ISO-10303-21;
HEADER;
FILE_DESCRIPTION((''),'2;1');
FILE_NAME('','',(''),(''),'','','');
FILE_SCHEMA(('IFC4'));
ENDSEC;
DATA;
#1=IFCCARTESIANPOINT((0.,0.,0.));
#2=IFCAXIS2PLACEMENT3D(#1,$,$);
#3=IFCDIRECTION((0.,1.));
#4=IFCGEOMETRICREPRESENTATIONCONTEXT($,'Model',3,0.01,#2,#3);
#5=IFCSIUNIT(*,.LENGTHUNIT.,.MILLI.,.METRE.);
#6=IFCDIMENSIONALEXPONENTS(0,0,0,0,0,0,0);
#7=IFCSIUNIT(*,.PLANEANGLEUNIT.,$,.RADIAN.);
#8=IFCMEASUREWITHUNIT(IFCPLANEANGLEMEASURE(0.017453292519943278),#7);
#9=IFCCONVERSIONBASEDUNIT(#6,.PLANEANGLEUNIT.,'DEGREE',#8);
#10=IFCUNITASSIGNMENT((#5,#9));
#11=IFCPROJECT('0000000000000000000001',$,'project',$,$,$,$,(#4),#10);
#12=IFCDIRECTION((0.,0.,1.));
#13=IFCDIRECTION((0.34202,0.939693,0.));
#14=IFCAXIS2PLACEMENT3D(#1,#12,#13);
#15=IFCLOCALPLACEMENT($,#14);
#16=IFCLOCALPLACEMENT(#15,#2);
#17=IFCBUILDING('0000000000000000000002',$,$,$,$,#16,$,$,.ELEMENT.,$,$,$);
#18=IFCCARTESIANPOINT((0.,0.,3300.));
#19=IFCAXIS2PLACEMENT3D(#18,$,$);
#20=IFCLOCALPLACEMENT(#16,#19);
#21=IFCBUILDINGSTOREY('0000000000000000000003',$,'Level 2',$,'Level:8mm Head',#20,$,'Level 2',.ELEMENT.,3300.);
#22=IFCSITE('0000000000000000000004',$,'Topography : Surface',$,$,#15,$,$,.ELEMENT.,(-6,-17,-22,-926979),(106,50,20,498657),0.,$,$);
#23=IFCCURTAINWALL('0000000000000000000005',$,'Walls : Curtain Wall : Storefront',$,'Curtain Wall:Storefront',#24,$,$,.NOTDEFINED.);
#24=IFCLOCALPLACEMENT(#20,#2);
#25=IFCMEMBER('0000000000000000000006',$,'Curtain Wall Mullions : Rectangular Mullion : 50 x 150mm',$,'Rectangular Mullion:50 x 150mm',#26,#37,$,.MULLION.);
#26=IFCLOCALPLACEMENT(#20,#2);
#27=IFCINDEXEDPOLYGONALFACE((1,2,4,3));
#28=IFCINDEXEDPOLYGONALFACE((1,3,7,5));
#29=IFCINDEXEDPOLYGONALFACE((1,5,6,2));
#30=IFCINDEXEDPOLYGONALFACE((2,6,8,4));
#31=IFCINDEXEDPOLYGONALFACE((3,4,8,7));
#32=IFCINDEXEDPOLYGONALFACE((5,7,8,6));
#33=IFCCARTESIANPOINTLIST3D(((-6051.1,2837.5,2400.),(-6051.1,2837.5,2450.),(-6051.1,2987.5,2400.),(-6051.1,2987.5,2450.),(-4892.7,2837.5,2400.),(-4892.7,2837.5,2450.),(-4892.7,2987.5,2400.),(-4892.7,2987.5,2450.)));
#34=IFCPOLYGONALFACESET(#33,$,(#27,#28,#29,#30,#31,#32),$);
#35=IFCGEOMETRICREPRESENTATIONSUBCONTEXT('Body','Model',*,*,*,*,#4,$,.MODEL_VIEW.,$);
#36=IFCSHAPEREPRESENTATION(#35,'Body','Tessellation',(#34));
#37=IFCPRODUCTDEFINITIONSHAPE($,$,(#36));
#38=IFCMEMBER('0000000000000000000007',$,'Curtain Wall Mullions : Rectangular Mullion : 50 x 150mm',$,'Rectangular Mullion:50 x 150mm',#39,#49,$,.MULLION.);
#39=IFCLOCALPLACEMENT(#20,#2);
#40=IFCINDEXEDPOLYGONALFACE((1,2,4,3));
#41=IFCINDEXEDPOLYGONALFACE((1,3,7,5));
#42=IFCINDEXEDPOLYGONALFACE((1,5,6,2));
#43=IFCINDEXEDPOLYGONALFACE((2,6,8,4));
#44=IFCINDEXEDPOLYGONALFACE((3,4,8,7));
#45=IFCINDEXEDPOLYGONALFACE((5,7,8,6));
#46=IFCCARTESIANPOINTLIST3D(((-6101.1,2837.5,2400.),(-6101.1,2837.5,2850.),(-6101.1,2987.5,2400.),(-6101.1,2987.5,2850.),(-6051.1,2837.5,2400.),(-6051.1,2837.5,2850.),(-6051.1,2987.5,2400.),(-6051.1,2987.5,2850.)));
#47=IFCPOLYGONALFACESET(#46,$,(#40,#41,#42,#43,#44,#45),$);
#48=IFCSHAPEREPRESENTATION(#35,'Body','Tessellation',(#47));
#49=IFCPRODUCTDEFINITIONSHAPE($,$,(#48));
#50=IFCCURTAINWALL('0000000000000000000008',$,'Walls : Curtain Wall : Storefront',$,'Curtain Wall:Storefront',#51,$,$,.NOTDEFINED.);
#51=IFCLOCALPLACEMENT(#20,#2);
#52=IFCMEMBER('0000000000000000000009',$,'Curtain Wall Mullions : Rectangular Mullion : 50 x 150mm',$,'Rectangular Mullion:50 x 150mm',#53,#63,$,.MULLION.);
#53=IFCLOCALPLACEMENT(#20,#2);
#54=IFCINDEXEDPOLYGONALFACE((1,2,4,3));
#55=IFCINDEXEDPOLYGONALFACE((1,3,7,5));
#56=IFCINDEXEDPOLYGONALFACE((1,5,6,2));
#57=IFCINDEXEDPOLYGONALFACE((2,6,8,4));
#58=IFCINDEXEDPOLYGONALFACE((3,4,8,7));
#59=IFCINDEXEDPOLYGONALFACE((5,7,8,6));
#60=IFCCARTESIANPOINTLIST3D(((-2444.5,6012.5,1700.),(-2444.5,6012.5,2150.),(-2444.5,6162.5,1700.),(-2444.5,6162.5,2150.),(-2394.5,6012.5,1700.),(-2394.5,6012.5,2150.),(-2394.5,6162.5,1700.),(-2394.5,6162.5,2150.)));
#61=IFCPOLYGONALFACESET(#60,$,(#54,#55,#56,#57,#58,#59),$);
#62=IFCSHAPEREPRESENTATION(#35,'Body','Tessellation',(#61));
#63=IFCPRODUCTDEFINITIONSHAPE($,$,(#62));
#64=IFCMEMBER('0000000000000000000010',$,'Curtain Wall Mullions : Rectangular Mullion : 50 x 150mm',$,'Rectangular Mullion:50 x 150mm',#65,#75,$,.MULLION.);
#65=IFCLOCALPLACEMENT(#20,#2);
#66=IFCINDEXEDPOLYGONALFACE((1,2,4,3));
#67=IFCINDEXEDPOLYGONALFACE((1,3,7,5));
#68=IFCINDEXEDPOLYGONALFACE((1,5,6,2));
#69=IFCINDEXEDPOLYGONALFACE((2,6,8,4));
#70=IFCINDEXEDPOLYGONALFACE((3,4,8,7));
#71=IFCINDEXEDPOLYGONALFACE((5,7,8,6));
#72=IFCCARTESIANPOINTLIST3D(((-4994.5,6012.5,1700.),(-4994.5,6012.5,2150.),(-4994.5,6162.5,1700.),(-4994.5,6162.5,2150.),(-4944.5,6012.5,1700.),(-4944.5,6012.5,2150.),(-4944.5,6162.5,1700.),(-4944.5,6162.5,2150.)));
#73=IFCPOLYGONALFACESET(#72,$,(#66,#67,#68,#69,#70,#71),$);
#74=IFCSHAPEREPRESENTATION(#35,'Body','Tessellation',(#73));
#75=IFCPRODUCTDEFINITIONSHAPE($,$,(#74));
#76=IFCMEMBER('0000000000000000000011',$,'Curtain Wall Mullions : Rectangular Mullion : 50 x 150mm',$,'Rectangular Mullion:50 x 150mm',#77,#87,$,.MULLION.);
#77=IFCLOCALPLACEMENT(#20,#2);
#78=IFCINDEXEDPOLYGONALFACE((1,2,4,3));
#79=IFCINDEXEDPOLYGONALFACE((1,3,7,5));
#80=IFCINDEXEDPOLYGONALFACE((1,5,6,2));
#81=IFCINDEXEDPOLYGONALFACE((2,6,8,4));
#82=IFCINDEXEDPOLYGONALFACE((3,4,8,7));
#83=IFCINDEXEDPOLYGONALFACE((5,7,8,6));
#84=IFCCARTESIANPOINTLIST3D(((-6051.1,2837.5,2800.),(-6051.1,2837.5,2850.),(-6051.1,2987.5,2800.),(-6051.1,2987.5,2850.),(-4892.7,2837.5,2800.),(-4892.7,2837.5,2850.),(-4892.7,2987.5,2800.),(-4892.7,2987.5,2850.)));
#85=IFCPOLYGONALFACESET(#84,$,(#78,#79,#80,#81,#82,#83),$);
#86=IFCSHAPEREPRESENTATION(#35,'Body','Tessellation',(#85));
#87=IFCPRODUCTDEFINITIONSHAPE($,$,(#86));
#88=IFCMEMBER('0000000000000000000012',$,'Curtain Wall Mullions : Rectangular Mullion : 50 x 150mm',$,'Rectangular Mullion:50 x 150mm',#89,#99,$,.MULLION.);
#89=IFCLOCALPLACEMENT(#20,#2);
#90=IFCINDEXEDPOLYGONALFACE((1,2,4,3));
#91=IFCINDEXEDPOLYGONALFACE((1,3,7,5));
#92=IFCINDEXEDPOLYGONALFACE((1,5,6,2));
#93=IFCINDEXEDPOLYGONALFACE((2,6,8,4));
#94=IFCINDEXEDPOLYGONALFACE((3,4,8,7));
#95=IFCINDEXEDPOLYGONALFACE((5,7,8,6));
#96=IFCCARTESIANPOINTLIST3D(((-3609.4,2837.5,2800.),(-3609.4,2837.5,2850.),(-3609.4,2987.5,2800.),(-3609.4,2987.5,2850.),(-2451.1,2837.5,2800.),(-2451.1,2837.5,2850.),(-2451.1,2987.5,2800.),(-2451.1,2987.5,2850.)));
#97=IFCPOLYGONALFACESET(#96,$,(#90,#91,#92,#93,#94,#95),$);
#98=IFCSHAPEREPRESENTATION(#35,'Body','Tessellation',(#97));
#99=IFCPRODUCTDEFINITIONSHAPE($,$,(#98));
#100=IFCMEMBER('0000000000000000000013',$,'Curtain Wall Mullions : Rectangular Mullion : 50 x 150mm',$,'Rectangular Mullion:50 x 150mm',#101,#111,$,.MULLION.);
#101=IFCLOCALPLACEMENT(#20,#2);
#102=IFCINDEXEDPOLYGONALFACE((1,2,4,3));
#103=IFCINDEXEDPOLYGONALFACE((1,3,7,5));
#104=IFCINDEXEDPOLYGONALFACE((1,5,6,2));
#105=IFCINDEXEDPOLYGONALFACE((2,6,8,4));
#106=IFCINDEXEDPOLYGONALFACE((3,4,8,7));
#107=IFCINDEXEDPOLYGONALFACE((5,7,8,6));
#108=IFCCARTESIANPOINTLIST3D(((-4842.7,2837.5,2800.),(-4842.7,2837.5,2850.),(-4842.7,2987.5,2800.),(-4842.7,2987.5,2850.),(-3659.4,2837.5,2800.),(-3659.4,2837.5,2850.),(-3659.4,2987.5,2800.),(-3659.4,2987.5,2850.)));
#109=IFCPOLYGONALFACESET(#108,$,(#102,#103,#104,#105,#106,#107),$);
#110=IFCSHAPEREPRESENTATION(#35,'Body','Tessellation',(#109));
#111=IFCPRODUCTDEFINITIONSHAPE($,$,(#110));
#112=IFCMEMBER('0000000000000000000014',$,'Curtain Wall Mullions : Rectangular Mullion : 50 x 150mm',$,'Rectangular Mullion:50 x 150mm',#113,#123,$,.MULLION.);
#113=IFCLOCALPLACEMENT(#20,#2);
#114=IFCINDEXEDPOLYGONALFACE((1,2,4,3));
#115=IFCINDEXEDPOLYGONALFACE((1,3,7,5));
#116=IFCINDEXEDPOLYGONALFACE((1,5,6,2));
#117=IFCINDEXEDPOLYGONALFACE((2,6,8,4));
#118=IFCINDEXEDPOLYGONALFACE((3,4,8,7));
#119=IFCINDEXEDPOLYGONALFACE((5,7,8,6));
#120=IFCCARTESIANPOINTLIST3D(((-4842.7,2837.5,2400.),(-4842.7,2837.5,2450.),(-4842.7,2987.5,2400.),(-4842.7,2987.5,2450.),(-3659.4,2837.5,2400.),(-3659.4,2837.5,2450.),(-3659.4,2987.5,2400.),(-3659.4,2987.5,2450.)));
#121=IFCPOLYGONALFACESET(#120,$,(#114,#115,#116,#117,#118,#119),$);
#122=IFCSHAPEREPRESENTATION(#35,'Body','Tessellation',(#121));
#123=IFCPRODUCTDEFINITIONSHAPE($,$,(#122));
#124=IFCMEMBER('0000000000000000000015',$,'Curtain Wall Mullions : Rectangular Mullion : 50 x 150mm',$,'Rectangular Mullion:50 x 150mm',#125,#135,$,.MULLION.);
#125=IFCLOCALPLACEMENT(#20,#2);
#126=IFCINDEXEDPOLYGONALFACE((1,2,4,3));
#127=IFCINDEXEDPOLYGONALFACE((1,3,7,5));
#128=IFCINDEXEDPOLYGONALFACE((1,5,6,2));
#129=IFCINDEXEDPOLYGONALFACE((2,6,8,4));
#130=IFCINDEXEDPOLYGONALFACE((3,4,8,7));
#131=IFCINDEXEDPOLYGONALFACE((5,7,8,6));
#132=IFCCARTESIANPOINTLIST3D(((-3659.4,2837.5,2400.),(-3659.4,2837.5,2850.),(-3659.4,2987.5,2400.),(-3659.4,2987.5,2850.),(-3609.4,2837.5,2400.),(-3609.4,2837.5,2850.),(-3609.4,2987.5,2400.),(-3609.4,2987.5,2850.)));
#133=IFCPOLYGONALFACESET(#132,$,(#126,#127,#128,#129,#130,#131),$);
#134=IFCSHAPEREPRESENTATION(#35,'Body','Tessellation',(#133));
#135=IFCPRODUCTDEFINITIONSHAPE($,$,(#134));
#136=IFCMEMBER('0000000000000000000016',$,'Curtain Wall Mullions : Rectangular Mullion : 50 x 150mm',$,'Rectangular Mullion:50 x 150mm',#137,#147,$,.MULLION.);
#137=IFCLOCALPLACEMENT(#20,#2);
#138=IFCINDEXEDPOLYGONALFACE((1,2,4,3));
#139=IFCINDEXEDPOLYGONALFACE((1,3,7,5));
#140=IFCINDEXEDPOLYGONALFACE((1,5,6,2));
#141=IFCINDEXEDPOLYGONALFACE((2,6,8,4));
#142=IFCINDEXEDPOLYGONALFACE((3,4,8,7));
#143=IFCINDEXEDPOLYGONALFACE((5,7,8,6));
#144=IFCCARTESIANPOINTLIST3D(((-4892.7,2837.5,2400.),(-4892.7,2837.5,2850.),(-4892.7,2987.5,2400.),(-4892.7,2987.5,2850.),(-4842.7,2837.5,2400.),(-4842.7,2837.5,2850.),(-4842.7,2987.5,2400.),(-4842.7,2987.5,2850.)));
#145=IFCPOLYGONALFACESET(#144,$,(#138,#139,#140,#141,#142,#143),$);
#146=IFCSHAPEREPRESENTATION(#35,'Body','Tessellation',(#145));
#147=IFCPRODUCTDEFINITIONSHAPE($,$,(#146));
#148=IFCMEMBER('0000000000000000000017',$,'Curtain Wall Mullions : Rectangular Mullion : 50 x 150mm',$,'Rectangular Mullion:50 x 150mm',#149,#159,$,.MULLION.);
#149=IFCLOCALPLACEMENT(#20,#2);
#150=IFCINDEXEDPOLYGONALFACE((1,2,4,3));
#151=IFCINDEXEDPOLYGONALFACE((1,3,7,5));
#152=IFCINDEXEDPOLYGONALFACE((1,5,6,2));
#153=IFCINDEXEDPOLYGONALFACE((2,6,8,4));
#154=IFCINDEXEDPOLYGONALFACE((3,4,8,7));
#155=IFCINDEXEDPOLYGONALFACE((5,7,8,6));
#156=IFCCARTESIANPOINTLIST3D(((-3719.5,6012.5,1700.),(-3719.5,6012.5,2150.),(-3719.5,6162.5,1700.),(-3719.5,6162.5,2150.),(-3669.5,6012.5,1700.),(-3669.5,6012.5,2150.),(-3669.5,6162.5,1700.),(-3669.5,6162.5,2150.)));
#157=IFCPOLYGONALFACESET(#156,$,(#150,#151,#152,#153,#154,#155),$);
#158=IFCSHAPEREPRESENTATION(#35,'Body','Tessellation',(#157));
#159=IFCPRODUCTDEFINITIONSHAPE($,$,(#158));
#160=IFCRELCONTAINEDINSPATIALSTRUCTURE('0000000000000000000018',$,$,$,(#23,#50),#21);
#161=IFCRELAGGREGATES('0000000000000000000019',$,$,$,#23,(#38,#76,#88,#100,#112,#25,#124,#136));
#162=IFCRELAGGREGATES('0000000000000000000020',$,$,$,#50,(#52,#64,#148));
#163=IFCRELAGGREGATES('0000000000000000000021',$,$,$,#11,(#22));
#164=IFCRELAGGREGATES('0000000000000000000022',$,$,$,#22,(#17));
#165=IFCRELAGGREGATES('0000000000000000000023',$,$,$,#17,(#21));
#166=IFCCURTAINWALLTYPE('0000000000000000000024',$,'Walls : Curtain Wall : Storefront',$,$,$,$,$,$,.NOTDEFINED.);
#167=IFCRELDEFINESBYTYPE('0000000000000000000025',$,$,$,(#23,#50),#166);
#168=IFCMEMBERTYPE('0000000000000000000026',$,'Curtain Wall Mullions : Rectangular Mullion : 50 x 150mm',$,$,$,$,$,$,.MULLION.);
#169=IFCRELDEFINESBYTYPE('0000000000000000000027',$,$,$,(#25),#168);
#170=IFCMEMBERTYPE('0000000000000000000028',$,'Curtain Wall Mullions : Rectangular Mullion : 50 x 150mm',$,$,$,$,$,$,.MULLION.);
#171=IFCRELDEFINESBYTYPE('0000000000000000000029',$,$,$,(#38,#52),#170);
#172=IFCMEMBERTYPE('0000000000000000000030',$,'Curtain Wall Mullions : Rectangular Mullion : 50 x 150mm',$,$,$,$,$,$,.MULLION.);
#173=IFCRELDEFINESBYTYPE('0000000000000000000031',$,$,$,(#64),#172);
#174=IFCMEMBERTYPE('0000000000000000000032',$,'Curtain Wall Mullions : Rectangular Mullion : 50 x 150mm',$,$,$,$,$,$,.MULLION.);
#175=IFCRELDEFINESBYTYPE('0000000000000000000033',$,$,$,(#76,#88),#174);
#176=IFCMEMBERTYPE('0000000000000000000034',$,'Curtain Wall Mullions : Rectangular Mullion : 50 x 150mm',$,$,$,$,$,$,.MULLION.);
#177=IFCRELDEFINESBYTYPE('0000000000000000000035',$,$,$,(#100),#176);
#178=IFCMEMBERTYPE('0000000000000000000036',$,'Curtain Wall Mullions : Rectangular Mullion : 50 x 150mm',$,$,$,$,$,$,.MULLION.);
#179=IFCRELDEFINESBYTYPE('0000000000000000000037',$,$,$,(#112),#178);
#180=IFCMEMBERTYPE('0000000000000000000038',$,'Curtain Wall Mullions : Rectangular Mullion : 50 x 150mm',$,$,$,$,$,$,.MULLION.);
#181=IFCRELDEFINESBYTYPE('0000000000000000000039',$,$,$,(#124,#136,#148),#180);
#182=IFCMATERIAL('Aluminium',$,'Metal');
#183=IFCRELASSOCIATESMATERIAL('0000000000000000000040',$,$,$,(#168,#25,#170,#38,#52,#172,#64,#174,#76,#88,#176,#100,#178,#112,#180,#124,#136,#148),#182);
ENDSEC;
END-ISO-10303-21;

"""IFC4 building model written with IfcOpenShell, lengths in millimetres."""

from ifc_helpers import new_model, entity, si_unit, converted_unit, direction, frame, origin, place, context, subcontext, project, spatial, indexed_curve, outline, extrude, source, transform, mapped, material, type_object, type_shapes, element, aggregate, save


model = new_model("IFC4")

# Units and contexts
model_context = context("Model", 3, precision=0.01, world=origin(), true_north=direction((0.0, 1.0)))
body_context = subcontext(model_context, "Body", "Model", "MODEL_VIEW")
ifc_project = project(units=[si_unit("LENGTHUNIT", "METRE", prefix="MILLI"), converted_unit("PLANEANGLEUNIT", "DEGREE", entity("IfcPlaneAngleMeasure", 0.017453292519943278), si_unit("PLANEANGLEUNIT", "RADIAN"), dimensions=[0, 0, 0, 0, 0, 0, 0])], contexts=[model_context])

# Site, building, storey
site_placement = place(None, frame((0.0, 0.0, 0.0), z_axis=(0.0, 0.0, 1.0), x_axis=(0.34202, 0.939693, 0.0)))
site = spatial("IfcSite", under=ifc_project, at=site_placement, Name="Topography : Surface", CompositionType="ELEMENT", RefLatitude=(-6, -17, -22, -926979), RefLongitude=(106, 50, 20, 498657), RefElevation=0.0)
building_placement = place(site_placement, origin())
building = spatial("IfcBuilding", under=site, at=building_placement, CompositionType="ELEMENT")
storey_placement = place(building_placement, frame((0.0, 0.0, 3300.0)))
storey = spatial("IfcBuildingStorey", under=building, at=storey_placement, Name="Level 2", ObjectType="Level:8mm Head", LongName="Level 2", CompositionType="ELEMENT", Elevation=3300.0)

# Curtain walls, members
curtain_wall_type = type_object("IfcCurtainWallType", Name="Walls : Curtain Wall : Storefront", PredefinedType="NOTDEFINED")
curtain_wall_1_placement = place(storey_placement, frame((0.0, 0.0, -3300.0)))
curtain_wall_1 = element("IfcCurtainWall", 1, at=curtain_wall_1_placement, inside=storey, type_object=curtain_wall_type, Name="Walls : Curtain Wall : Storefront", ObjectType="Curtain Wall:Storefront", PredefinedType="NOTDEFINED")
ifc_material_1 = material(Name="Aluminium", Category="Metal")
member_type_1 = type_object("IfcMemberType", Name="Curtain Wall Mullions : Rectangular Mullion : 50 x 150mm", PredefinedType="MULLION", material=ifc_material_1)
shared_shape_1 = source(origin(), body_context, "Body", "SweptSolid", [
    extrude(outline(indexed_curve([(-25.0, -75.0), (25.0, -75.0), (25.0, 75.0), (-25.0, 75.0), (-25.0, -75.0)], self_intersect=False)), frame((-25.0, 0.0, -1158.3), z_axis=(0.0, 0.0, 1.0), x_axis=(-1.0, 0.0, 0.0)), (0.0, 0.0, 1.0), 1158.3),
])
type_shapes(member_type_1, [shared_shape_1])
member_1_placement = place(curtain_wall_1_placement, frame((-4892.7, 2912.5, 5700.0), z_axis=(1.0, 0.0, 0.0), x_axis=(0.0, 0.0, -1.0)))
member_1 = element("IfcMember", 2, at=member_1_placement, type_object=member_type_1, material=ifc_material_1, Name="Curtain Wall Mullions : Rectangular Mullion : 50 x 150mm", ObjectType="Rectangular Mullion:50 x 150mm", PredefinedType="MULLION", context=body_context, shape_type="MappedRepresentation", body=[
    mapped(shared_shape_1, transform((0.0, 0.0, 0.0), scale=1.0)),
])
member_type_2 = type_object("IfcMemberType", Name="Curtain Wall Mullions : Rectangular Mullion : 50 x 150mm", PredefinedType="MULLION", material=ifc_material_1)
shared_shape_2 = source(origin(), body_context, "Body", "SweptSolid", [
    extrude(outline(indexed_curve([(-25.0, -75.0), (25.0, -75.0), (25.0, 75.0), (-25.0, 75.0), (-25.0, -75.0)], self_intersect=False)), frame((-25.0, 0.0, -450.0), z_axis=(0.0, 0.0, 1.0), x_axis=(-1.0, 0.0, 0.0)), (0.0, 0.0, 1.0), 450.0),
])
type_shapes(member_type_2, [shared_shape_2])
member_2_placement = place(curtain_wall_1_placement, frame((-6101.1, 2912.5, 5700.0), z_axis=(0.0, 0.0, -1.0), x_axis=(-1.0, 0.0, 0.0)))
member_2 = element("IfcMember", 3, at=member_2_placement, type_object=member_type_2, material=ifc_material_1, Name="Curtain Wall Mullions : Rectangular Mullion : 50 x 150mm", ObjectType="Rectangular Mullion:50 x 150mm", PredefinedType="MULLION", context=body_context, shape_type="MappedRepresentation", body=[
    mapped(shared_shape_2, transform((0.0, 0.0, 0.0), scale=1.0)),
])
curtain_wall_2_placement = place(storey_placement, frame((0.0, 0.0, -3300.0)))
curtain_wall_2 = element("IfcCurtainWall", 4, at=curtain_wall_2_placement, inside=storey, type_object=curtain_wall_type, Name="Walls : Curtain Wall : Storefront", ObjectType="Curtain Wall:Storefront", PredefinedType="NOTDEFINED")
member_3_placement = place(curtain_wall_2_placement, frame((-2394.5, 6087.5, 5000.0), z_axis=(0.0, 0.0, -1.0), x_axis=(1.0, 0.0, 0.0)))
member_3 = element("IfcMember", 5, at=member_3_placement, type_object=member_type_2, material=ifc_material_1, Name="Curtain Wall Mullions : Rectangular Mullion : 50 x 150mm", ObjectType="Rectangular Mullion:50 x 150mm", PredefinedType="MULLION", context=body_context, shape_type="MappedRepresentation", body=[
    mapped(shared_shape_2, transform((0.0, 0.0, 0.0), scale=1.0)),
])
member_type_3 = type_object("IfcMemberType", Name="Curtain Wall Mullions : Rectangular Mullion : 50 x 150mm", PredefinedType="MULLION", material=ifc_material_1)
shared_shape_3 = source(origin(), body_context, "Body", "SweptSolid", [
    extrude(outline(indexed_curve([(-25.0, -75.0), (25.0, -75.0), (25.0, 75.0), (-25.0, 75.0), (-25.0, -75.0)], self_intersect=False)), frame((-25.0, 0.0, -450.0), z_axis=(0.0, 0.0, 1.0), x_axis=(-1.0, 0.0, 0.0)), (0.0, 0.0, 1.0), 450.0),
])
type_shapes(member_type_3, [shared_shape_3])
member_4_placement = place(curtain_wall_2_placement, frame((-4994.5, 6087.5, 5450.0), z_axis=(0.0, 0.0, 1.0), x_axis=(-1.0, 0.0, 0.0)))
member_4 = element("IfcMember", 6, at=member_4_placement, type_object=member_type_3, material=ifc_material_1, Name="Curtain Wall Mullions : Rectangular Mullion : 50 x 150mm", ObjectType="Rectangular Mullion:50 x 150mm", PredefinedType="MULLION", context=body_context, shape_type="MappedRepresentation", body=[
    mapped(shared_shape_3, transform((0.0, 0.0, 0.0), scale=1.0)),
])

# Members
member_type_4 = type_object("IfcMemberType", Name="Curtain Wall Mullions : Rectangular Mullion : 50 x 150mm", PredefinedType="MULLION", material=ifc_material_1)
shared_shape_4 = source(origin(), body_context, "Body", "SweptSolid", [
    extrude(outline(indexed_curve([(-25.0, -75.0), (25.0, -75.0), (25.0, 75.0), (-25.0, 75.0), (-25.0, -75.0)], self_intersect=False)), frame((-25.0, 0.0, -1158.3), z_axis=(0.0, 0.0, 1.0), x_axis=(-1.0, 0.0, 0.0)), (0.0, 0.0, 1.0), 1158.3),
])
type_shapes(member_type_4, [shared_shape_4])
member_5_placement = place(curtain_wall_1_placement, frame((-6051.1, 2912.5, 6150.0), z_axis=(-1.0, 0.0, 0.0), x_axis=(0.0, 0.0, 1.0)))
member_5 = element("IfcMember", 7, at=member_5_placement, type_object=member_type_4, material=ifc_material_1, Name="Curtain Wall Mullions : Rectangular Mullion : 50 x 150mm", ObjectType="Rectangular Mullion:50 x 150mm", PredefinedType="MULLION", context=body_context, shape_type="MappedRepresentation", body=[
    mapped(shared_shape_4, transform((0.0, 0.0, 0.0), scale=1.0)),
])
member_6_placement = place(curtain_wall_1_placement, frame((-3609.4, 2912.5, 6150.0), z_axis=(-1.0, 0.0, 0.0), x_axis=(0.0, 0.0, 1.0)))
member_6 = element("IfcMember", 8, at=member_6_placement, type_object=member_type_4, material=ifc_material_1, Name="Curtain Wall Mullions : Rectangular Mullion : 50 x 150mm", ObjectType="Rectangular Mullion:50 x 150mm", PredefinedType="MULLION", context=body_context, shape_type="MappedRepresentation", body=[
    mapped(shared_shape_4, transform((0.0, 0.0, 0.0), scale=1.0)),
])
member_type_5 = type_object("IfcMemberType", Name="Curtain Wall Mullions : Rectangular Mullion : 50 x 150mm", PredefinedType="MULLION", material=ifc_material_1)
shared_shape_5 = source(origin(), body_context, "Body", "SweptSolid", [
    extrude(outline(indexed_curve([(-25.0, -75.0), (25.0, -75.0), (25.0, 75.0), (-25.0, 75.0), (-25.0, -75.0)], self_intersect=False)), frame((-25.0, 0.0, -1183.3), z_axis=(0.0, 0.0, 1.0), x_axis=(-1.0, 0.0, 0.0)), (0.0, 0.0, 1.0), 1183.3),
])
type_shapes(member_type_5, [shared_shape_5])
member_7_placement = place(curtain_wall_1_placement, frame((-4842.7, 2912.5, 6150.0), z_axis=(-1.0, 0.0, 0.0), x_axis=(0.0, 0.0, 1.0)))
member_7 = element("IfcMember", 9, at=member_7_placement, type_object=member_type_5, material=ifc_material_1, Name="Curtain Wall Mullions : Rectangular Mullion : 50 x 150mm", ObjectType="Rectangular Mullion:50 x 150mm", PredefinedType="MULLION", context=body_context, shape_type="MappedRepresentation", body=[
    mapped(shared_shape_5, transform((0.0, 0.0, 0.0), scale=1.0)),
])
member_type_6 = type_object("IfcMemberType", Name="Curtain Wall Mullions : Rectangular Mullion : 50 x 150mm", PredefinedType="MULLION", material=ifc_material_1)
shared_shape_6 = source(origin(), body_context, "Body", "SweptSolid", [
    extrude(outline(indexed_curve([(-25.0, -75.0), (25.0, -75.0), (25.0, 75.0), (-25.0, 75.0), (-25.0, -75.0)], self_intersect=False)), frame((-25.0, 0.0, -1183.3), z_axis=(0.0, 0.0, 1.0), x_axis=(-1.0, 0.0, 0.0)), (0.0, 0.0, 1.0), 1183.3),
])
type_shapes(member_type_6, [shared_shape_6])
member_8_placement = place(curtain_wall_1_placement, frame((-3659.4, 2912.5, 5700.0), z_axis=(1.0, 0.0, 0.0), x_axis=(0.0, 0.0, -1.0)))
member_8 = element("IfcMember", 10, at=member_8_placement, type_object=member_type_6, material=ifc_material_1, Name="Curtain Wall Mullions : Rectangular Mullion : 50 x 150mm", ObjectType="Rectangular Mullion:50 x 150mm", PredefinedType="MULLION", context=body_context, shape_type="MappedRepresentation", body=[
    mapped(shared_shape_6, transform((0.0, 0.0, 0.0), scale=1.0)),
])
member_type_7 = type_object("IfcMemberType", Name="Curtain Wall Mullions : Rectangular Mullion : 50 x 150mm", PredefinedType="MULLION", material=ifc_material_1)
shared_shape_7 = source(origin(), body_context, "Body", "SweptSolid", [
    extrude(outline(indexed_curve([(-25.0, -75.0), (25.0, -75.0), (25.0, 75.0), (-25.0, 75.0), (-25.0, -75.0)], self_intersect=False)), frame((0.0, 0.0, -450.0), z_axis=(0.0, 0.0, 1.0), x_axis=(-1.0, 0.0, 0.0)), (0.0, 0.0, 1.0), 450.0),
])
type_shapes(member_type_7, [shared_shape_7])
member_9_placement = place(curtain_wall_1_placement, frame((-3634.4, 2912.5, 5700.0), z_axis=(0.0, 0.0, -1.0), x_axis=(-1.0, 0.0, 0.0)))
member_9 = element("IfcMember", 11, at=member_9_placement, type_object=member_type_7, material=ifc_material_1, Name="Curtain Wall Mullions : Rectangular Mullion : 50 x 150mm", ObjectType="Rectangular Mullion:50 x 150mm", PredefinedType="MULLION", context=body_context, shape_type="MappedRepresentation", body=[
    mapped(shared_shape_7, transform((0.0, 0.0, 0.0), scale=1.0)),
])
member_10_placement = place(curtain_wall_1_placement, frame((-4867.7, 2912.5, 5700.0), z_axis=(0.0, 0.0, -1.0), x_axis=(-1.0, 0.0, 0.0)))
member_10 = element("IfcMember", 12, at=member_10_placement, type_object=member_type_7, material=ifc_material_1, Name="Curtain Wall Mullions : Rectangular Mullion : 50 x 150mm", ObjectType="Rectangular Mullion:50 x 150mm", PredefinedType="MULLION", context=body_context, shape_type="MappedRepresentation", body=[
    mapped(shared_shape_7, transform((0.0, 0.0, 0.0), scale=1.0)),
])
member_11_placement = place(curtain_wall_2_placement, frame((-3694.5, 6087.5, 5000.0), z_axis=(0.0, 0.0, -1.0), x_axis=(1.0, 0.0, 0.0)))
member_11 = element("IfcMember", 13, at=member_11_placement, type_object=member_type_7, material=ifc_material_1, Name="Curtain Wall Mullions : Rectangular Mullion : 50 x 150mm", ObjectType="Rectangular Mullion:50 x 150mm", PredefinedType="MULLION", context=body_context, shape_type="MappedRepresentation", body=[
    mapped(shared_shape_7, transform((0.0, 0.0, 0.0), scale=1.0)),
])

aggregate(curtain_wall_1, [member_2, member_5, member_6, member_7, member_8, member_1, member_9, member_10])
aggregate(curtain_wall_2, [member_3, member_4, member_11])

save(model, "model.ifc")
